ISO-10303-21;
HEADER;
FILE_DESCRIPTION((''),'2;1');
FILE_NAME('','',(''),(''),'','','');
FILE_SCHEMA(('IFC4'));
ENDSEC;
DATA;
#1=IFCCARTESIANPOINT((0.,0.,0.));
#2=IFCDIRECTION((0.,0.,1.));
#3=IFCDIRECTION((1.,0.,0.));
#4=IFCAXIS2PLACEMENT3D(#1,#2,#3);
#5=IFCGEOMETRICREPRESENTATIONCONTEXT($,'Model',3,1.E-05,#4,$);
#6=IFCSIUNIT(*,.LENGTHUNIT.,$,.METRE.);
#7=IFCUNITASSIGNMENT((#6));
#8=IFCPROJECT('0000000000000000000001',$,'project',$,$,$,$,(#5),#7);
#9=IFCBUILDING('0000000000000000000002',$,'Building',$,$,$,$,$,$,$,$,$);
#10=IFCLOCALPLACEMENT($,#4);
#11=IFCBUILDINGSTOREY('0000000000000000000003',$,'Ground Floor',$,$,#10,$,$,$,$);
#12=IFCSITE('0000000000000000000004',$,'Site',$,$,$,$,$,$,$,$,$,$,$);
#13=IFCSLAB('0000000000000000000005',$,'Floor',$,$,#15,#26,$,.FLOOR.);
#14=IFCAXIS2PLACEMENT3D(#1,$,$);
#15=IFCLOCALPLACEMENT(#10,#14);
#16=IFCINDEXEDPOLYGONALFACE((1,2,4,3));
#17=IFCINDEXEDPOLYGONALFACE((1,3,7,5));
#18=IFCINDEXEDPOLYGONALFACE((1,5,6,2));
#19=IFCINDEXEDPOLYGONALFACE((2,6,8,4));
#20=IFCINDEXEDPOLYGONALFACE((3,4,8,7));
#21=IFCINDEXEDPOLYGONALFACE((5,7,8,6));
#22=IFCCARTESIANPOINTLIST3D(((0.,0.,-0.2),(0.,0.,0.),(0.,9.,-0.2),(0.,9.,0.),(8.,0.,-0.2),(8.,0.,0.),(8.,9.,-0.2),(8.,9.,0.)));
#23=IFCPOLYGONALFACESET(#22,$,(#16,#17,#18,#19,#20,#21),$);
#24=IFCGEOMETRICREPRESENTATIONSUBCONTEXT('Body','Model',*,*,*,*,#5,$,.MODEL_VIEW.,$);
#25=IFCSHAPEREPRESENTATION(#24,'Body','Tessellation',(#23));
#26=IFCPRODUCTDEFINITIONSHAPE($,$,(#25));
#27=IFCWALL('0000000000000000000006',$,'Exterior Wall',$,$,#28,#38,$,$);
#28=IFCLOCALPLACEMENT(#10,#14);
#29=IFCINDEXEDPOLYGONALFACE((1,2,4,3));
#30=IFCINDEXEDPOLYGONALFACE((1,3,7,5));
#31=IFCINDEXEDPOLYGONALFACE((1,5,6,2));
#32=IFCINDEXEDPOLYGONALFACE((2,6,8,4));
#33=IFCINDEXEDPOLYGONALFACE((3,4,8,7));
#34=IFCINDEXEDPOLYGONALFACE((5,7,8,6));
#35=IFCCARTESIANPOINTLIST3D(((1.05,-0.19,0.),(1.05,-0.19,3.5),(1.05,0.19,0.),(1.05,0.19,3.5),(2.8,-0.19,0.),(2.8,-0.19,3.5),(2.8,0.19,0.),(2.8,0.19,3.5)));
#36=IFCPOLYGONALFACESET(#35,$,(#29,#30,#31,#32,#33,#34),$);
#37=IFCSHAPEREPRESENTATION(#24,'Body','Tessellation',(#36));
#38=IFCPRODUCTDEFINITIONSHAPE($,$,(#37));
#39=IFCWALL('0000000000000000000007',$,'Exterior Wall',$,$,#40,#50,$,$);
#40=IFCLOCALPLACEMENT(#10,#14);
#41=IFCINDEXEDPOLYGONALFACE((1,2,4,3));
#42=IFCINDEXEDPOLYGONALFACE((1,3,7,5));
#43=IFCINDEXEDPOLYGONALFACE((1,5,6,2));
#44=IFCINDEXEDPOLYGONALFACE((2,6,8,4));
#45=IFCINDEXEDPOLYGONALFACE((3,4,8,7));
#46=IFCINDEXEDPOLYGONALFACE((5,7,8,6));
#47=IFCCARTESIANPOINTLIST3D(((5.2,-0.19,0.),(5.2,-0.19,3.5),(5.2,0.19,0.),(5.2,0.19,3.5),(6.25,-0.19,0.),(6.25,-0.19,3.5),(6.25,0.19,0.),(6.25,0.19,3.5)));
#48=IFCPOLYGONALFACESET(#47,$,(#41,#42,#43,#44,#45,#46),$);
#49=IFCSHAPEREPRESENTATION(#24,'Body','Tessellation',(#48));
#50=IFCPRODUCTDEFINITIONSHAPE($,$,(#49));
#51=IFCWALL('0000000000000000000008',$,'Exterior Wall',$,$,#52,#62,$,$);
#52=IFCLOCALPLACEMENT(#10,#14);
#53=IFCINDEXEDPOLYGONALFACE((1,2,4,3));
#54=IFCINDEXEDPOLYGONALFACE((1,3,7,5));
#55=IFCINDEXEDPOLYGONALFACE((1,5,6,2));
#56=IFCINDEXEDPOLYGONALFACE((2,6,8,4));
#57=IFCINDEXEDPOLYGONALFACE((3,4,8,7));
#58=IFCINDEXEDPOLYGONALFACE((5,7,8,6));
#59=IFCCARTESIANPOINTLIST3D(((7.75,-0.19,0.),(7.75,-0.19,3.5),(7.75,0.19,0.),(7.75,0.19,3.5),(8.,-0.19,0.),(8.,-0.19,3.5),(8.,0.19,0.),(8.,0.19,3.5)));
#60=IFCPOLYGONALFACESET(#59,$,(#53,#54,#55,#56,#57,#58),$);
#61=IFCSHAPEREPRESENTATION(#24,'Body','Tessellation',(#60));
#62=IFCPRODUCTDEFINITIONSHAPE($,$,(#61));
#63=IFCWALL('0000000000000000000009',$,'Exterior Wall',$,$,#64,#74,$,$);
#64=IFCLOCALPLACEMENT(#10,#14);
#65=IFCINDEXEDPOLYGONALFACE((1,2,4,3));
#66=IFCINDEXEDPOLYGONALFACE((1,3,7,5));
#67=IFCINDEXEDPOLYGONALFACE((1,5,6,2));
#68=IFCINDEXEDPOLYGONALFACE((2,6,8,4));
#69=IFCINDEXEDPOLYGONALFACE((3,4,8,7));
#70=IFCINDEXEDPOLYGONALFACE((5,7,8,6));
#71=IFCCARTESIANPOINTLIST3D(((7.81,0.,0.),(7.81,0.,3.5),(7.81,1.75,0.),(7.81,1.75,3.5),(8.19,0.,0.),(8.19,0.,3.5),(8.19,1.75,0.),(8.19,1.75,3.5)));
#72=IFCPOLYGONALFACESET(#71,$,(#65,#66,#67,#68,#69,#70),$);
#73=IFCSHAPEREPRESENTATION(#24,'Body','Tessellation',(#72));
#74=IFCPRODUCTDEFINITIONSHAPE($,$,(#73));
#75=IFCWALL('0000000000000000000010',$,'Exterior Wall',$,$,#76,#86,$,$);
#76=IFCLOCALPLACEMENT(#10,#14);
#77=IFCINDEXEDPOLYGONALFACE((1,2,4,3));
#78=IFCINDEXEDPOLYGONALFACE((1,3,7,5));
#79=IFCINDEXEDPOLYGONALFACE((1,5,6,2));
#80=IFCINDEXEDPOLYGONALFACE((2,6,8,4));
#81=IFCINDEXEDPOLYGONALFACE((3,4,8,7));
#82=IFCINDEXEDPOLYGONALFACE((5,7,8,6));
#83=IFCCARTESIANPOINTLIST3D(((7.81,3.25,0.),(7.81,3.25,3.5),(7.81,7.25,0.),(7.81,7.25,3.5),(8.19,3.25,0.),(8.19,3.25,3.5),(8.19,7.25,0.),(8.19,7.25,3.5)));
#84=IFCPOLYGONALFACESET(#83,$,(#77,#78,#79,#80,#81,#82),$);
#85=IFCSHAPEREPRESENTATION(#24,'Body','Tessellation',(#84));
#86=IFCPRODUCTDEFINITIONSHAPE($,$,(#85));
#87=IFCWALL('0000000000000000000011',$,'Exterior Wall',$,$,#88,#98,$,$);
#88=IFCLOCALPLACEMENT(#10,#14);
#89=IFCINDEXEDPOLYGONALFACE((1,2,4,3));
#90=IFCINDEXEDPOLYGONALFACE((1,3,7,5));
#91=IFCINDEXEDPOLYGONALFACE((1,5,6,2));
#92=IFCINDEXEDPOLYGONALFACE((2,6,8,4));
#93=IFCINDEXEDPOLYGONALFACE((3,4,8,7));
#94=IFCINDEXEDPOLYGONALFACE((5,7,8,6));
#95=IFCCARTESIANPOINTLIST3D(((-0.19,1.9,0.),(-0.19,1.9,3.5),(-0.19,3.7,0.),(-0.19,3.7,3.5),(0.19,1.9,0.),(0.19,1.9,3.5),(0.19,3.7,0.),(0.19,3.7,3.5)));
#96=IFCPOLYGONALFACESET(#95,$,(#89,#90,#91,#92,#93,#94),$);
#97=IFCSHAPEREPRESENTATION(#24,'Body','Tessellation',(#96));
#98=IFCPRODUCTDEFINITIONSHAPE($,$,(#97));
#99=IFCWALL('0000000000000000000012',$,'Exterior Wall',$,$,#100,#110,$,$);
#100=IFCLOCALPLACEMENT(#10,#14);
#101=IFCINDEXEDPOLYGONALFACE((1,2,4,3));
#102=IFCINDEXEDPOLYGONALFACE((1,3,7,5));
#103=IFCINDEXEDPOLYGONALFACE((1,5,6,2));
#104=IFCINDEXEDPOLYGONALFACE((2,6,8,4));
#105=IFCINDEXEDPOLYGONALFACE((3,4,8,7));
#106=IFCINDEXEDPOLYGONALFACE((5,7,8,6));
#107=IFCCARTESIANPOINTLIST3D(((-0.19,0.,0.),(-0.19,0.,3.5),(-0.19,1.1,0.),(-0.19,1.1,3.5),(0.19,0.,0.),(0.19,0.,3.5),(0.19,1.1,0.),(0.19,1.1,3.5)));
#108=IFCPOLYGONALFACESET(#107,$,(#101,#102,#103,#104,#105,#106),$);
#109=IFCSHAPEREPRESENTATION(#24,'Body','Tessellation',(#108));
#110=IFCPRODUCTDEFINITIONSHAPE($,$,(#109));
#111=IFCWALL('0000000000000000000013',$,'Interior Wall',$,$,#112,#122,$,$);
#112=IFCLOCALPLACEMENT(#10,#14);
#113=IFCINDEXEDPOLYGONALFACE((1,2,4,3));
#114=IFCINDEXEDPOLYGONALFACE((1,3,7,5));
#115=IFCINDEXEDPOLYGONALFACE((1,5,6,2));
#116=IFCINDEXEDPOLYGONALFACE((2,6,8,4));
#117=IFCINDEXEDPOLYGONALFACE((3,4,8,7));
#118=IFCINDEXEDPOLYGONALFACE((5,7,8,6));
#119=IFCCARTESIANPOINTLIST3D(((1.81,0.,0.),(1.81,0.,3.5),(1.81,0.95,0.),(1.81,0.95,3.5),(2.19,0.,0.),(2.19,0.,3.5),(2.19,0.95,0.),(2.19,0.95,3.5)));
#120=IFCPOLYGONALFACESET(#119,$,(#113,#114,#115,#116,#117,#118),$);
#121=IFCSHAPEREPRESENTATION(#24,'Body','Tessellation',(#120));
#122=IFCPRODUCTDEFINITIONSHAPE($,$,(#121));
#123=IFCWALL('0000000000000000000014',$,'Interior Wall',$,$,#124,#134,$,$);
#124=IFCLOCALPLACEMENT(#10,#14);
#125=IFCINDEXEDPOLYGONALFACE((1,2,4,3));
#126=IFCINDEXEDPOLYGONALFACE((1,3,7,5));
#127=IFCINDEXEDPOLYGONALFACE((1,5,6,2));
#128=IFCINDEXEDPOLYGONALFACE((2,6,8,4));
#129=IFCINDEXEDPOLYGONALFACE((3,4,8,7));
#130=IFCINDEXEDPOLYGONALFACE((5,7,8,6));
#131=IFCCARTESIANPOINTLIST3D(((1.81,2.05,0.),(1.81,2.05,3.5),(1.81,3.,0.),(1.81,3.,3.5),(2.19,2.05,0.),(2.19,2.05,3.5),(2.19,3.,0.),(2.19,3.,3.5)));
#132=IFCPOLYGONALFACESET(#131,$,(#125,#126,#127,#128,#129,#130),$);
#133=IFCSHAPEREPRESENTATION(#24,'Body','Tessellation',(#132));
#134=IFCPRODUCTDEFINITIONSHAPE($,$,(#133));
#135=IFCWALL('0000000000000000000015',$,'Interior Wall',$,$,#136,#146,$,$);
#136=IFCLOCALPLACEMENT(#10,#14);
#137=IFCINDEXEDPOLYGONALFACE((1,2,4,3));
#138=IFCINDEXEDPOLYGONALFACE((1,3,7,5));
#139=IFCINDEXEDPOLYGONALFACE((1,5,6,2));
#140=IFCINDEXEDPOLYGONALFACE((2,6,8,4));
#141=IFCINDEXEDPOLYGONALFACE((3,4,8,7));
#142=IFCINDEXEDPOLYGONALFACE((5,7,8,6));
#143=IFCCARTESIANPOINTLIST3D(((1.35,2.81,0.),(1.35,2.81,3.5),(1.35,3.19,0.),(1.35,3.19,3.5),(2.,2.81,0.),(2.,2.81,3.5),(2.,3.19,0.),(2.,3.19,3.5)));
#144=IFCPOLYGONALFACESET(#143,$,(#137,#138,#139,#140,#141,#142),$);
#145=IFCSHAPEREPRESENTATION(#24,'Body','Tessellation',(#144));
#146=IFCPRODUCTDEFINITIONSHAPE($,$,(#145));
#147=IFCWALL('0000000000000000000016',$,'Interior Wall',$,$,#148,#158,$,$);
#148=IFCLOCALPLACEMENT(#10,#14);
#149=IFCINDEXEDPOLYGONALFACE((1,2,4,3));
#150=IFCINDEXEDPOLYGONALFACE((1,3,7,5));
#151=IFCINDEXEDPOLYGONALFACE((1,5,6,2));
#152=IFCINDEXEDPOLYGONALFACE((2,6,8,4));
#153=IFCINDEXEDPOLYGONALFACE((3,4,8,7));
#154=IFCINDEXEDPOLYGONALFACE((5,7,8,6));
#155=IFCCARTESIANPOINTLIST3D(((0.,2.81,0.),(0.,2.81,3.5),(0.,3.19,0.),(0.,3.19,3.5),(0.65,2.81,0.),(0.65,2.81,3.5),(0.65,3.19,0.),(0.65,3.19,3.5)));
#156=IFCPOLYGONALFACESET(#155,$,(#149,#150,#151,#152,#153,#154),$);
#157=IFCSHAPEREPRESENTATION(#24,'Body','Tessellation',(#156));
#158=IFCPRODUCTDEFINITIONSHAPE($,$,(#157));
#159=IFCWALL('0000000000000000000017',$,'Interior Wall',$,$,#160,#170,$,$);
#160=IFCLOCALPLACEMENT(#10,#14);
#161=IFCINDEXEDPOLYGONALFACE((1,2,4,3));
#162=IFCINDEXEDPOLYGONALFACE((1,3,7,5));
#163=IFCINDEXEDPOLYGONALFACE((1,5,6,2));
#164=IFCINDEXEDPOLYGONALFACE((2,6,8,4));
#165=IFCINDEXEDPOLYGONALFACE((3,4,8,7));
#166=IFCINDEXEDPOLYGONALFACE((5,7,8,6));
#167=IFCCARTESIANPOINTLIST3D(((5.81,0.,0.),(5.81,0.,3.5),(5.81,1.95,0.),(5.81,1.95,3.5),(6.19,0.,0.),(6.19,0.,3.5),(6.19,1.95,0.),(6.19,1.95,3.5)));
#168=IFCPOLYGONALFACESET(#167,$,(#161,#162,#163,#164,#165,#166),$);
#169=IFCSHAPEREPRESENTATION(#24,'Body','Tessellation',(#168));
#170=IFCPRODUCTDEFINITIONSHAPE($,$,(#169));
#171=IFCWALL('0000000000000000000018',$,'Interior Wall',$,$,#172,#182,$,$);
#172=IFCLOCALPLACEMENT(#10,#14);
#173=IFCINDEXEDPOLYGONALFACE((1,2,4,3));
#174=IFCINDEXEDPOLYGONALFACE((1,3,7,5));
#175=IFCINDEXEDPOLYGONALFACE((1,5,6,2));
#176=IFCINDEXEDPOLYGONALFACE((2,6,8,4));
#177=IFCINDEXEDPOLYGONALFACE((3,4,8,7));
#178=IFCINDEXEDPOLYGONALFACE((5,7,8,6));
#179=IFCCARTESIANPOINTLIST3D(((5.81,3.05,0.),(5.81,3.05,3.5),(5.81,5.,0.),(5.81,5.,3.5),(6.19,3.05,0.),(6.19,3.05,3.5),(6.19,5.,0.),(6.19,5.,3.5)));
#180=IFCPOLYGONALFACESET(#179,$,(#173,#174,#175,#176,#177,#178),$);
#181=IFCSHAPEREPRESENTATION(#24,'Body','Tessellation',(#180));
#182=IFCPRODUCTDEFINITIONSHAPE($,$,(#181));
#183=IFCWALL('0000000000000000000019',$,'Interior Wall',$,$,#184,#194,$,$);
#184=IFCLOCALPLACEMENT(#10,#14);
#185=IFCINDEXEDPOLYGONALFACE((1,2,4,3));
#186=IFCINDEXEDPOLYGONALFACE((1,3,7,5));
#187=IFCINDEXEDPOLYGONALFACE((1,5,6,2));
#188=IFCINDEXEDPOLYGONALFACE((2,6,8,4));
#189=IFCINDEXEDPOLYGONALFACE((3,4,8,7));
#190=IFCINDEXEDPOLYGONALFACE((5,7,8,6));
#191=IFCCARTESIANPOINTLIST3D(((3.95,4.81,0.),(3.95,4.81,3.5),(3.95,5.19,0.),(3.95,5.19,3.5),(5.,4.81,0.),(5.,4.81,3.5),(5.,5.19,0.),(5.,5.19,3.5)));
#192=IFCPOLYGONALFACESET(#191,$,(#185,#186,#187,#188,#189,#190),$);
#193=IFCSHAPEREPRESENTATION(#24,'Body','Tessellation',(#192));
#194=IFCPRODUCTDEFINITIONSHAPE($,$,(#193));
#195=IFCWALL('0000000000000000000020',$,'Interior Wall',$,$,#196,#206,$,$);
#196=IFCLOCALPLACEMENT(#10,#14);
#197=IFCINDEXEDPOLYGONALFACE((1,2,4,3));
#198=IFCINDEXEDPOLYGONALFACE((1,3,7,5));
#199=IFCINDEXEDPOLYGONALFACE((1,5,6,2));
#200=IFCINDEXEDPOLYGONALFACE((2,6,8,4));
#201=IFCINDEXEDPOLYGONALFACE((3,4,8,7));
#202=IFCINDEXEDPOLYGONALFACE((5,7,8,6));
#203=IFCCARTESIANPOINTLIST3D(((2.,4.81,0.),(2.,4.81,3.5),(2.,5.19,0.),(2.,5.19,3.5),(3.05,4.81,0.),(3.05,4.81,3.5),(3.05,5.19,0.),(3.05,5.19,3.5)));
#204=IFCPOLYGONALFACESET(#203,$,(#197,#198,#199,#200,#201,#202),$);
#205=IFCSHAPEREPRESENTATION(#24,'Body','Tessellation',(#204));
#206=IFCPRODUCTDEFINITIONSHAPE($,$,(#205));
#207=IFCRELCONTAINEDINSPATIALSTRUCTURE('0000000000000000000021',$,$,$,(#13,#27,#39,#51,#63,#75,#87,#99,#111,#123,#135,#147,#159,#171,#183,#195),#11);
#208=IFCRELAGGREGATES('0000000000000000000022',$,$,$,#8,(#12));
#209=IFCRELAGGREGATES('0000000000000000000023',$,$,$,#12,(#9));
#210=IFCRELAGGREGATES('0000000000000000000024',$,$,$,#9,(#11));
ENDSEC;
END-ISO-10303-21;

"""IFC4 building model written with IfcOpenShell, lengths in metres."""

from ifc_helpers import new_model, si_unit, frame, origin_with_axes, place, context, subcontext, project, spatial, indexed_curve, outline, extrude, element, save


model = new_model("IFC4")

# Units and contexts
model_context = context("Model", 3, precision=1e-05, world=origin_with_axes())
body_context = subcontext(model_context, "Body", "Model", "MODEL_VIEW")
ifc_project = project(units=[si_unit("LENGTHUNIT", "METRE")], contexts=[model_context])

# Site, building, storey
site = spatial("IfcSite", under=ifc_project, Name="Site")
building = spatial("IfcBuilding", under=site, Name="Building")
storey_placement = place(None, origin_with_axes())
storey = spatial("IfcBuildingStorey", under=building, at=storey_placement, Name="Ground Floor")

# Slab
slab_placement = place(storey_placement, frame((0.0, 0.0, -0.2), z_axis=(0.0, 0.0, 1.0), x_axis=(1.0, 0.0, 0.0)))
element("IfcSlab", 1, at=slab_placement, inside=storey, Name="Floor", PredefinedType="FLOOR", context=body_context, shape_type="SweptSolid", body=[
    extrude(outline(indexed_curve([(0.0, 0.0), (8.0, 0.0), (8.0, 9.0), (0.0, 9.0)])), None, (0.0, 0.0, 1.0), 0.2),
])

# Walls
wall_1_placement = place(storey_placement, frame((1.05, 0.0, 0.0), z_axis=(0.0, 0.0, 1.0), x_axis=(1.0, 0.0, 0.0)))
element("IfcWall", 2, at=wall_1_placement, inside=storey, Name="Exterior Wall", context=body_context, shape_type="SweptSolid", body=[
    extrude(outline(indexed_curve([(0.0, 0.0), (0.0, 0.38), (1.75, 0.38), (1.75, 0.0), (0.0, 0.0)], self_intersect=False)), frame((0.0, -0.19, 0.0), z_axis=(0.0, 0.0, 1.0), x_axis=(1.0, 0.0, 0.0)), (0.0, 0.0, 1.0), 3.5),
])
wall_2_placement = place(storey_placement, frame((5.2, 0.0, 0.0), z_axis=(0.0, 0.0, 1.0), x_axis=(1.0, 0.0, 0.0)))
element("IfcWall", 3, at=wall_2_placement, inside=storey, Name="Exterior Wall", context=body_context, shape_type="SweptSolid", body=[
    extrude(outline(indexed_curve([(0.0, 0.0), (0.0, 0.38), (1.05, 0.38), (1.05, 0.0), (0.0, 0.0)], self_intersect=False)), frame((0.0, -0.19, 0.0), z_axis=(0.0, 0.0, 1.0), x_axis=(1.0, 0.0, 0.0)), (0.0, 0.0, 1.0), 3.5),
])
wall_3_placement = place(storey_placement, frame((7.75, 0.0, 0.0), z_axis=(0.0, 0.0, 1.0), x_axis=(1.0, 0.0, 0.0)))
element("IfcWall", 4, at=wall_3_placement, inside=storey, Name="Exterior Wall", context=body_context, shape_type="SweptSolid", body=[
    extrude(outline(indexed_curve([(0.0, 0.0), (0.0, 0.38), (0.25, 0.38), (0.25, 0.0), (0.0, 0.0)], self_intersect=False)), frame((0.0, -0.19, 0.0), z_axis=(0.0, 0.0, 1.0), x_axis=(1.0, 0.0, 0.0)), (0.0, 0.0, 1.0), 3.5),
])
wall_4_placement = place(storey_placement, frame((8.0, 0.0, 0.0), z_axis=(0.0, 0.0, 1.0), x_axis=(0.0, 1.0, 0.0)))
element("IfcWall", 5, at=wall_4_placement, inside=storey, Name="Exterior Wall", context=body_context, shape_type="SweptSolid", body=[
    extrude(outline(indexed_curve([(0.0, 0.0), (0.0, 0.38), (1.75, 0.38), (1.75, 0.0), (0.0, 0.0)], self_intersect=False)), frame((0.0, -0.19, 0.0), z_axis=(0.0, 0.0, 1.0), x_axis=(1.0, 0.0, 0.0)), (0.0, 0.0, 1.0), 3.5),
])
wall_5_placement = place(storey_placement, frame((8.0, 3.25, 0.0), z_axis=(0.0, 0.0, 1.0), x_axis=(0.0, 1.0, 0.0)))
element("IfcWall", 6, at=wall_5_placement, inside=storey, Name="Exterior Wall", context=body_context, shape_type="SweptSolid", body=[
    extrude(outline(indexed_curve([(0.0, 0.0), (0.0, 0.38), (4.0, 0.38), (4.0, 0.0), (0.0, 0.0)], self_intersect=False)), frame((0.0, -0.19, 0.0), z_axis=(0.0, 0.0, 1.0), x_axis=(1.0, 0.0, 0.0)), (0.0, 0.0, 1.0), 3.5),
])
wall_6_placement = place(storey_placement, frame((0.0, 3.7, 0.0), z_axis=(0.0, 0.0, 1.0), x_axis=(0.0, -1.0, 0.0)))
element("IfcWall", 7, at=wall_6_placement, inside=storey, Name="Exterior Wall", context=body_context, shape_type="SweptSolid", body=[
    extrude(outline(indexed_curve([(0.0, 0.0), (0.0, 0.38), (1.8, 0.38), (1.8, 0.0), (0.0, 0.0)], self_intersect=False)), frame((0.0, -0.19, 0.0), z_axis=(0.0, 0.0, 1.0), x_axis=(1.0, 0.0, 0.0)), (0.0, 0.0, 1.0), 3.5),
])
wall_7_placement = place(storey_placement, frame((0.0, 1.1, 0.0), z_axis=(0.0, 0.0, 1.0), x_axis=(0.0, -1.0, 0.0)))
element("IfcWall", 8, at=wall_7_placement, inside=storey, Name="Exterior Wall", context=body_context, shape_type="SweptSolid", body=[
    extrude(outline(indexed_curve([(0.0, 0.0), (0.0, 0.38), (1.1, 0.38), (1.1, 0.0), (0.0, 0.0)], self_intersect=False)), frame((0.0, -0.19, 0.0), z_axis=(0.0, 0.0, 1.0), x_axis=(1.0, 0.0, 0.0)), (0.0, 0.0, 1.0), 3.5),
])
wall_8_placement = place(storey_placement, frame((2.0, 0.0, 0.0), z_axis=(0.0, 0.0, 1.0), x_axis=(0.0, 1.0, 0.0)))
element("IfcWall", 9, at=wall_8_placement, inside=storey, Name="Interior Wall", context=body_context, shape_type="SweptSolid", body=[
    extrude(outline(indexed_curve([(0.0, 0.0), (0.0, 0.38), (0.95, 0.38), (0.95, 0.0), (0.0, 0.0)], self_intersect=False)), frame((0.0, -0.19, 0.0), z_axis=(0.0, 0.0, 1.0), x_axis=(1.0, 0.0, 0.0)), (0.0, 0.0, 1.0), 3.5),
])
wall_9_placement = place(storey_placement, frame((2.0, 2.05, 0.0), z_axis=(0.0, 0.0, 1.0), x_axis=(0.0, 1.0, 0.0)))
element("IfcWall", 10, at=wall_9_placement, inside=storey, Name="Interior Wall", context=body_context, shape_type="SweptSolid", body=[
    extrude(outline(indexed_curve([(0.0, 0.0), (0.0, 0.38), (0.95, 0.38), (0.95, 0.0), (0.0, 0.0)], self_intersect=False)), frame((0.0, -0.19, 0.0), z_axis=(0.0, 0.0, 1.0), x_axis=(1.0, 0.0, 0.0)), (0.0, 0.0, 1.0), 3.5),
])
for number, where, z_axis, x_axis, name in (
    (11, (2.0, 3.0, 0.0), (0.0, 0.0, 1.0), (-1.0, 0.0, 0.0), "Interior Wall"),
    (12, (0.65, 3.0, 0.0), (0.0, 0.0, 1.0), (-1.0, 0.0, 0.0), "Interior Wall"),
):
    element("IfcWall", number, at=place(storey_placement, frame(where, z_axis=z_axis, x_axis=x_axis)), inside=storey, Name=name, context=body_context, shape_type="SweptSolid", body=[
        extrude(outline(indexed_curve([(0.0, 0.0), (0.0, 0.38), (0.65, 0.38), (0.65, 0.0), (0.0, 0.0)], self_intersect=False)), frame((0.0, -0.19, 0.0), z_axis=(0.0, 0.0, 1.0), x_axis=(1.0, 0.0, 0.0)), (0.0, 0.0, 1.0), 3.5),
    ])
wall_10_placement = place(storey_placement, frame((6.0, 0.0, 0.0), z_axis=(0.0, 0.0, 1.0), x_axis=(0.0, 1.0, 0.0)))
element("IfcWall", 13, at=wall_10_placement, inside=storey, Name="Interior Wall", context=body_context, shape_type="SweptSolid", body=[
    extrude(outline(indexed_curve([(0.0, 0.0), (0.0, 0.38), (1.95, 0.38), (1.95, 0.0), (0.0, 0.0)], self_intersect=False)), frame((0.0, -0.19, 0.0), z_axis=(0.0, 0.0, 1.0), x_axis=(1.0, 0.0, 0.0)), (0.0, 0.0, 1.0), 3.5),
])
wall_11_placement = place(storey_placement, frame((6.0, 3.05, 0.0), z_axis=(0.0, 0.0, 1.0), x_axis=(0.0, 1.0, 0.0)))
element("IfcWall", 14, at=wall_11_placement, inside=storey, Name="Interior Wall", context=body_context, shape_type="SweptSolid", body=[
    extrude(outline(indexed_curve([(0.0, 0.0), (0.0, 0.38), (1.95, 0.38), (1.95, 0.0), (0.0, 0.0)], self_intersect=False)), frame((0.0, -0.19, 0.0), z_axis=(0.0, 0.0, 1.0), x_axis=(1.0, 0.0, 0.0)), (0.0, 0.0, 1.0), 3.5),
])
for number, where, z_axis, x_axis, name in (
    (15, (5.0, 5.0, 0.0), (0.0, 0.0, 1.0), (-1.0, 0.0, 0.0), "Interior Wall"),
    (16, (3.05, 5.0, 0.0), (0.0, 0.0, 1.0), (-1.0, 0.0, 0.0), "Interior Wall"),
):
    element("IfcWall", number, at=place(storey_placement, frame(where, z_axis=z_axis, x_axis=x_axis)), inside=storey, Name=name, context=body_context, shape_type="SweptSolid", body=[
        extrude(outline(indexed_curve([(0.0, 0.0), (0.0, 0.38), (1.05, 0.38), (1.05, 0.0), (0.0, 0.0)], self_intersect=False)), frame((0.0, -0.19, 0.0), z_axis=(0.0, 0.0, 1.0), x_axis=(1.0, 0.0, 0.0)), (0.0, 0.0, 1.0), 3.5),
    ])

save(model, "model.ifc")
